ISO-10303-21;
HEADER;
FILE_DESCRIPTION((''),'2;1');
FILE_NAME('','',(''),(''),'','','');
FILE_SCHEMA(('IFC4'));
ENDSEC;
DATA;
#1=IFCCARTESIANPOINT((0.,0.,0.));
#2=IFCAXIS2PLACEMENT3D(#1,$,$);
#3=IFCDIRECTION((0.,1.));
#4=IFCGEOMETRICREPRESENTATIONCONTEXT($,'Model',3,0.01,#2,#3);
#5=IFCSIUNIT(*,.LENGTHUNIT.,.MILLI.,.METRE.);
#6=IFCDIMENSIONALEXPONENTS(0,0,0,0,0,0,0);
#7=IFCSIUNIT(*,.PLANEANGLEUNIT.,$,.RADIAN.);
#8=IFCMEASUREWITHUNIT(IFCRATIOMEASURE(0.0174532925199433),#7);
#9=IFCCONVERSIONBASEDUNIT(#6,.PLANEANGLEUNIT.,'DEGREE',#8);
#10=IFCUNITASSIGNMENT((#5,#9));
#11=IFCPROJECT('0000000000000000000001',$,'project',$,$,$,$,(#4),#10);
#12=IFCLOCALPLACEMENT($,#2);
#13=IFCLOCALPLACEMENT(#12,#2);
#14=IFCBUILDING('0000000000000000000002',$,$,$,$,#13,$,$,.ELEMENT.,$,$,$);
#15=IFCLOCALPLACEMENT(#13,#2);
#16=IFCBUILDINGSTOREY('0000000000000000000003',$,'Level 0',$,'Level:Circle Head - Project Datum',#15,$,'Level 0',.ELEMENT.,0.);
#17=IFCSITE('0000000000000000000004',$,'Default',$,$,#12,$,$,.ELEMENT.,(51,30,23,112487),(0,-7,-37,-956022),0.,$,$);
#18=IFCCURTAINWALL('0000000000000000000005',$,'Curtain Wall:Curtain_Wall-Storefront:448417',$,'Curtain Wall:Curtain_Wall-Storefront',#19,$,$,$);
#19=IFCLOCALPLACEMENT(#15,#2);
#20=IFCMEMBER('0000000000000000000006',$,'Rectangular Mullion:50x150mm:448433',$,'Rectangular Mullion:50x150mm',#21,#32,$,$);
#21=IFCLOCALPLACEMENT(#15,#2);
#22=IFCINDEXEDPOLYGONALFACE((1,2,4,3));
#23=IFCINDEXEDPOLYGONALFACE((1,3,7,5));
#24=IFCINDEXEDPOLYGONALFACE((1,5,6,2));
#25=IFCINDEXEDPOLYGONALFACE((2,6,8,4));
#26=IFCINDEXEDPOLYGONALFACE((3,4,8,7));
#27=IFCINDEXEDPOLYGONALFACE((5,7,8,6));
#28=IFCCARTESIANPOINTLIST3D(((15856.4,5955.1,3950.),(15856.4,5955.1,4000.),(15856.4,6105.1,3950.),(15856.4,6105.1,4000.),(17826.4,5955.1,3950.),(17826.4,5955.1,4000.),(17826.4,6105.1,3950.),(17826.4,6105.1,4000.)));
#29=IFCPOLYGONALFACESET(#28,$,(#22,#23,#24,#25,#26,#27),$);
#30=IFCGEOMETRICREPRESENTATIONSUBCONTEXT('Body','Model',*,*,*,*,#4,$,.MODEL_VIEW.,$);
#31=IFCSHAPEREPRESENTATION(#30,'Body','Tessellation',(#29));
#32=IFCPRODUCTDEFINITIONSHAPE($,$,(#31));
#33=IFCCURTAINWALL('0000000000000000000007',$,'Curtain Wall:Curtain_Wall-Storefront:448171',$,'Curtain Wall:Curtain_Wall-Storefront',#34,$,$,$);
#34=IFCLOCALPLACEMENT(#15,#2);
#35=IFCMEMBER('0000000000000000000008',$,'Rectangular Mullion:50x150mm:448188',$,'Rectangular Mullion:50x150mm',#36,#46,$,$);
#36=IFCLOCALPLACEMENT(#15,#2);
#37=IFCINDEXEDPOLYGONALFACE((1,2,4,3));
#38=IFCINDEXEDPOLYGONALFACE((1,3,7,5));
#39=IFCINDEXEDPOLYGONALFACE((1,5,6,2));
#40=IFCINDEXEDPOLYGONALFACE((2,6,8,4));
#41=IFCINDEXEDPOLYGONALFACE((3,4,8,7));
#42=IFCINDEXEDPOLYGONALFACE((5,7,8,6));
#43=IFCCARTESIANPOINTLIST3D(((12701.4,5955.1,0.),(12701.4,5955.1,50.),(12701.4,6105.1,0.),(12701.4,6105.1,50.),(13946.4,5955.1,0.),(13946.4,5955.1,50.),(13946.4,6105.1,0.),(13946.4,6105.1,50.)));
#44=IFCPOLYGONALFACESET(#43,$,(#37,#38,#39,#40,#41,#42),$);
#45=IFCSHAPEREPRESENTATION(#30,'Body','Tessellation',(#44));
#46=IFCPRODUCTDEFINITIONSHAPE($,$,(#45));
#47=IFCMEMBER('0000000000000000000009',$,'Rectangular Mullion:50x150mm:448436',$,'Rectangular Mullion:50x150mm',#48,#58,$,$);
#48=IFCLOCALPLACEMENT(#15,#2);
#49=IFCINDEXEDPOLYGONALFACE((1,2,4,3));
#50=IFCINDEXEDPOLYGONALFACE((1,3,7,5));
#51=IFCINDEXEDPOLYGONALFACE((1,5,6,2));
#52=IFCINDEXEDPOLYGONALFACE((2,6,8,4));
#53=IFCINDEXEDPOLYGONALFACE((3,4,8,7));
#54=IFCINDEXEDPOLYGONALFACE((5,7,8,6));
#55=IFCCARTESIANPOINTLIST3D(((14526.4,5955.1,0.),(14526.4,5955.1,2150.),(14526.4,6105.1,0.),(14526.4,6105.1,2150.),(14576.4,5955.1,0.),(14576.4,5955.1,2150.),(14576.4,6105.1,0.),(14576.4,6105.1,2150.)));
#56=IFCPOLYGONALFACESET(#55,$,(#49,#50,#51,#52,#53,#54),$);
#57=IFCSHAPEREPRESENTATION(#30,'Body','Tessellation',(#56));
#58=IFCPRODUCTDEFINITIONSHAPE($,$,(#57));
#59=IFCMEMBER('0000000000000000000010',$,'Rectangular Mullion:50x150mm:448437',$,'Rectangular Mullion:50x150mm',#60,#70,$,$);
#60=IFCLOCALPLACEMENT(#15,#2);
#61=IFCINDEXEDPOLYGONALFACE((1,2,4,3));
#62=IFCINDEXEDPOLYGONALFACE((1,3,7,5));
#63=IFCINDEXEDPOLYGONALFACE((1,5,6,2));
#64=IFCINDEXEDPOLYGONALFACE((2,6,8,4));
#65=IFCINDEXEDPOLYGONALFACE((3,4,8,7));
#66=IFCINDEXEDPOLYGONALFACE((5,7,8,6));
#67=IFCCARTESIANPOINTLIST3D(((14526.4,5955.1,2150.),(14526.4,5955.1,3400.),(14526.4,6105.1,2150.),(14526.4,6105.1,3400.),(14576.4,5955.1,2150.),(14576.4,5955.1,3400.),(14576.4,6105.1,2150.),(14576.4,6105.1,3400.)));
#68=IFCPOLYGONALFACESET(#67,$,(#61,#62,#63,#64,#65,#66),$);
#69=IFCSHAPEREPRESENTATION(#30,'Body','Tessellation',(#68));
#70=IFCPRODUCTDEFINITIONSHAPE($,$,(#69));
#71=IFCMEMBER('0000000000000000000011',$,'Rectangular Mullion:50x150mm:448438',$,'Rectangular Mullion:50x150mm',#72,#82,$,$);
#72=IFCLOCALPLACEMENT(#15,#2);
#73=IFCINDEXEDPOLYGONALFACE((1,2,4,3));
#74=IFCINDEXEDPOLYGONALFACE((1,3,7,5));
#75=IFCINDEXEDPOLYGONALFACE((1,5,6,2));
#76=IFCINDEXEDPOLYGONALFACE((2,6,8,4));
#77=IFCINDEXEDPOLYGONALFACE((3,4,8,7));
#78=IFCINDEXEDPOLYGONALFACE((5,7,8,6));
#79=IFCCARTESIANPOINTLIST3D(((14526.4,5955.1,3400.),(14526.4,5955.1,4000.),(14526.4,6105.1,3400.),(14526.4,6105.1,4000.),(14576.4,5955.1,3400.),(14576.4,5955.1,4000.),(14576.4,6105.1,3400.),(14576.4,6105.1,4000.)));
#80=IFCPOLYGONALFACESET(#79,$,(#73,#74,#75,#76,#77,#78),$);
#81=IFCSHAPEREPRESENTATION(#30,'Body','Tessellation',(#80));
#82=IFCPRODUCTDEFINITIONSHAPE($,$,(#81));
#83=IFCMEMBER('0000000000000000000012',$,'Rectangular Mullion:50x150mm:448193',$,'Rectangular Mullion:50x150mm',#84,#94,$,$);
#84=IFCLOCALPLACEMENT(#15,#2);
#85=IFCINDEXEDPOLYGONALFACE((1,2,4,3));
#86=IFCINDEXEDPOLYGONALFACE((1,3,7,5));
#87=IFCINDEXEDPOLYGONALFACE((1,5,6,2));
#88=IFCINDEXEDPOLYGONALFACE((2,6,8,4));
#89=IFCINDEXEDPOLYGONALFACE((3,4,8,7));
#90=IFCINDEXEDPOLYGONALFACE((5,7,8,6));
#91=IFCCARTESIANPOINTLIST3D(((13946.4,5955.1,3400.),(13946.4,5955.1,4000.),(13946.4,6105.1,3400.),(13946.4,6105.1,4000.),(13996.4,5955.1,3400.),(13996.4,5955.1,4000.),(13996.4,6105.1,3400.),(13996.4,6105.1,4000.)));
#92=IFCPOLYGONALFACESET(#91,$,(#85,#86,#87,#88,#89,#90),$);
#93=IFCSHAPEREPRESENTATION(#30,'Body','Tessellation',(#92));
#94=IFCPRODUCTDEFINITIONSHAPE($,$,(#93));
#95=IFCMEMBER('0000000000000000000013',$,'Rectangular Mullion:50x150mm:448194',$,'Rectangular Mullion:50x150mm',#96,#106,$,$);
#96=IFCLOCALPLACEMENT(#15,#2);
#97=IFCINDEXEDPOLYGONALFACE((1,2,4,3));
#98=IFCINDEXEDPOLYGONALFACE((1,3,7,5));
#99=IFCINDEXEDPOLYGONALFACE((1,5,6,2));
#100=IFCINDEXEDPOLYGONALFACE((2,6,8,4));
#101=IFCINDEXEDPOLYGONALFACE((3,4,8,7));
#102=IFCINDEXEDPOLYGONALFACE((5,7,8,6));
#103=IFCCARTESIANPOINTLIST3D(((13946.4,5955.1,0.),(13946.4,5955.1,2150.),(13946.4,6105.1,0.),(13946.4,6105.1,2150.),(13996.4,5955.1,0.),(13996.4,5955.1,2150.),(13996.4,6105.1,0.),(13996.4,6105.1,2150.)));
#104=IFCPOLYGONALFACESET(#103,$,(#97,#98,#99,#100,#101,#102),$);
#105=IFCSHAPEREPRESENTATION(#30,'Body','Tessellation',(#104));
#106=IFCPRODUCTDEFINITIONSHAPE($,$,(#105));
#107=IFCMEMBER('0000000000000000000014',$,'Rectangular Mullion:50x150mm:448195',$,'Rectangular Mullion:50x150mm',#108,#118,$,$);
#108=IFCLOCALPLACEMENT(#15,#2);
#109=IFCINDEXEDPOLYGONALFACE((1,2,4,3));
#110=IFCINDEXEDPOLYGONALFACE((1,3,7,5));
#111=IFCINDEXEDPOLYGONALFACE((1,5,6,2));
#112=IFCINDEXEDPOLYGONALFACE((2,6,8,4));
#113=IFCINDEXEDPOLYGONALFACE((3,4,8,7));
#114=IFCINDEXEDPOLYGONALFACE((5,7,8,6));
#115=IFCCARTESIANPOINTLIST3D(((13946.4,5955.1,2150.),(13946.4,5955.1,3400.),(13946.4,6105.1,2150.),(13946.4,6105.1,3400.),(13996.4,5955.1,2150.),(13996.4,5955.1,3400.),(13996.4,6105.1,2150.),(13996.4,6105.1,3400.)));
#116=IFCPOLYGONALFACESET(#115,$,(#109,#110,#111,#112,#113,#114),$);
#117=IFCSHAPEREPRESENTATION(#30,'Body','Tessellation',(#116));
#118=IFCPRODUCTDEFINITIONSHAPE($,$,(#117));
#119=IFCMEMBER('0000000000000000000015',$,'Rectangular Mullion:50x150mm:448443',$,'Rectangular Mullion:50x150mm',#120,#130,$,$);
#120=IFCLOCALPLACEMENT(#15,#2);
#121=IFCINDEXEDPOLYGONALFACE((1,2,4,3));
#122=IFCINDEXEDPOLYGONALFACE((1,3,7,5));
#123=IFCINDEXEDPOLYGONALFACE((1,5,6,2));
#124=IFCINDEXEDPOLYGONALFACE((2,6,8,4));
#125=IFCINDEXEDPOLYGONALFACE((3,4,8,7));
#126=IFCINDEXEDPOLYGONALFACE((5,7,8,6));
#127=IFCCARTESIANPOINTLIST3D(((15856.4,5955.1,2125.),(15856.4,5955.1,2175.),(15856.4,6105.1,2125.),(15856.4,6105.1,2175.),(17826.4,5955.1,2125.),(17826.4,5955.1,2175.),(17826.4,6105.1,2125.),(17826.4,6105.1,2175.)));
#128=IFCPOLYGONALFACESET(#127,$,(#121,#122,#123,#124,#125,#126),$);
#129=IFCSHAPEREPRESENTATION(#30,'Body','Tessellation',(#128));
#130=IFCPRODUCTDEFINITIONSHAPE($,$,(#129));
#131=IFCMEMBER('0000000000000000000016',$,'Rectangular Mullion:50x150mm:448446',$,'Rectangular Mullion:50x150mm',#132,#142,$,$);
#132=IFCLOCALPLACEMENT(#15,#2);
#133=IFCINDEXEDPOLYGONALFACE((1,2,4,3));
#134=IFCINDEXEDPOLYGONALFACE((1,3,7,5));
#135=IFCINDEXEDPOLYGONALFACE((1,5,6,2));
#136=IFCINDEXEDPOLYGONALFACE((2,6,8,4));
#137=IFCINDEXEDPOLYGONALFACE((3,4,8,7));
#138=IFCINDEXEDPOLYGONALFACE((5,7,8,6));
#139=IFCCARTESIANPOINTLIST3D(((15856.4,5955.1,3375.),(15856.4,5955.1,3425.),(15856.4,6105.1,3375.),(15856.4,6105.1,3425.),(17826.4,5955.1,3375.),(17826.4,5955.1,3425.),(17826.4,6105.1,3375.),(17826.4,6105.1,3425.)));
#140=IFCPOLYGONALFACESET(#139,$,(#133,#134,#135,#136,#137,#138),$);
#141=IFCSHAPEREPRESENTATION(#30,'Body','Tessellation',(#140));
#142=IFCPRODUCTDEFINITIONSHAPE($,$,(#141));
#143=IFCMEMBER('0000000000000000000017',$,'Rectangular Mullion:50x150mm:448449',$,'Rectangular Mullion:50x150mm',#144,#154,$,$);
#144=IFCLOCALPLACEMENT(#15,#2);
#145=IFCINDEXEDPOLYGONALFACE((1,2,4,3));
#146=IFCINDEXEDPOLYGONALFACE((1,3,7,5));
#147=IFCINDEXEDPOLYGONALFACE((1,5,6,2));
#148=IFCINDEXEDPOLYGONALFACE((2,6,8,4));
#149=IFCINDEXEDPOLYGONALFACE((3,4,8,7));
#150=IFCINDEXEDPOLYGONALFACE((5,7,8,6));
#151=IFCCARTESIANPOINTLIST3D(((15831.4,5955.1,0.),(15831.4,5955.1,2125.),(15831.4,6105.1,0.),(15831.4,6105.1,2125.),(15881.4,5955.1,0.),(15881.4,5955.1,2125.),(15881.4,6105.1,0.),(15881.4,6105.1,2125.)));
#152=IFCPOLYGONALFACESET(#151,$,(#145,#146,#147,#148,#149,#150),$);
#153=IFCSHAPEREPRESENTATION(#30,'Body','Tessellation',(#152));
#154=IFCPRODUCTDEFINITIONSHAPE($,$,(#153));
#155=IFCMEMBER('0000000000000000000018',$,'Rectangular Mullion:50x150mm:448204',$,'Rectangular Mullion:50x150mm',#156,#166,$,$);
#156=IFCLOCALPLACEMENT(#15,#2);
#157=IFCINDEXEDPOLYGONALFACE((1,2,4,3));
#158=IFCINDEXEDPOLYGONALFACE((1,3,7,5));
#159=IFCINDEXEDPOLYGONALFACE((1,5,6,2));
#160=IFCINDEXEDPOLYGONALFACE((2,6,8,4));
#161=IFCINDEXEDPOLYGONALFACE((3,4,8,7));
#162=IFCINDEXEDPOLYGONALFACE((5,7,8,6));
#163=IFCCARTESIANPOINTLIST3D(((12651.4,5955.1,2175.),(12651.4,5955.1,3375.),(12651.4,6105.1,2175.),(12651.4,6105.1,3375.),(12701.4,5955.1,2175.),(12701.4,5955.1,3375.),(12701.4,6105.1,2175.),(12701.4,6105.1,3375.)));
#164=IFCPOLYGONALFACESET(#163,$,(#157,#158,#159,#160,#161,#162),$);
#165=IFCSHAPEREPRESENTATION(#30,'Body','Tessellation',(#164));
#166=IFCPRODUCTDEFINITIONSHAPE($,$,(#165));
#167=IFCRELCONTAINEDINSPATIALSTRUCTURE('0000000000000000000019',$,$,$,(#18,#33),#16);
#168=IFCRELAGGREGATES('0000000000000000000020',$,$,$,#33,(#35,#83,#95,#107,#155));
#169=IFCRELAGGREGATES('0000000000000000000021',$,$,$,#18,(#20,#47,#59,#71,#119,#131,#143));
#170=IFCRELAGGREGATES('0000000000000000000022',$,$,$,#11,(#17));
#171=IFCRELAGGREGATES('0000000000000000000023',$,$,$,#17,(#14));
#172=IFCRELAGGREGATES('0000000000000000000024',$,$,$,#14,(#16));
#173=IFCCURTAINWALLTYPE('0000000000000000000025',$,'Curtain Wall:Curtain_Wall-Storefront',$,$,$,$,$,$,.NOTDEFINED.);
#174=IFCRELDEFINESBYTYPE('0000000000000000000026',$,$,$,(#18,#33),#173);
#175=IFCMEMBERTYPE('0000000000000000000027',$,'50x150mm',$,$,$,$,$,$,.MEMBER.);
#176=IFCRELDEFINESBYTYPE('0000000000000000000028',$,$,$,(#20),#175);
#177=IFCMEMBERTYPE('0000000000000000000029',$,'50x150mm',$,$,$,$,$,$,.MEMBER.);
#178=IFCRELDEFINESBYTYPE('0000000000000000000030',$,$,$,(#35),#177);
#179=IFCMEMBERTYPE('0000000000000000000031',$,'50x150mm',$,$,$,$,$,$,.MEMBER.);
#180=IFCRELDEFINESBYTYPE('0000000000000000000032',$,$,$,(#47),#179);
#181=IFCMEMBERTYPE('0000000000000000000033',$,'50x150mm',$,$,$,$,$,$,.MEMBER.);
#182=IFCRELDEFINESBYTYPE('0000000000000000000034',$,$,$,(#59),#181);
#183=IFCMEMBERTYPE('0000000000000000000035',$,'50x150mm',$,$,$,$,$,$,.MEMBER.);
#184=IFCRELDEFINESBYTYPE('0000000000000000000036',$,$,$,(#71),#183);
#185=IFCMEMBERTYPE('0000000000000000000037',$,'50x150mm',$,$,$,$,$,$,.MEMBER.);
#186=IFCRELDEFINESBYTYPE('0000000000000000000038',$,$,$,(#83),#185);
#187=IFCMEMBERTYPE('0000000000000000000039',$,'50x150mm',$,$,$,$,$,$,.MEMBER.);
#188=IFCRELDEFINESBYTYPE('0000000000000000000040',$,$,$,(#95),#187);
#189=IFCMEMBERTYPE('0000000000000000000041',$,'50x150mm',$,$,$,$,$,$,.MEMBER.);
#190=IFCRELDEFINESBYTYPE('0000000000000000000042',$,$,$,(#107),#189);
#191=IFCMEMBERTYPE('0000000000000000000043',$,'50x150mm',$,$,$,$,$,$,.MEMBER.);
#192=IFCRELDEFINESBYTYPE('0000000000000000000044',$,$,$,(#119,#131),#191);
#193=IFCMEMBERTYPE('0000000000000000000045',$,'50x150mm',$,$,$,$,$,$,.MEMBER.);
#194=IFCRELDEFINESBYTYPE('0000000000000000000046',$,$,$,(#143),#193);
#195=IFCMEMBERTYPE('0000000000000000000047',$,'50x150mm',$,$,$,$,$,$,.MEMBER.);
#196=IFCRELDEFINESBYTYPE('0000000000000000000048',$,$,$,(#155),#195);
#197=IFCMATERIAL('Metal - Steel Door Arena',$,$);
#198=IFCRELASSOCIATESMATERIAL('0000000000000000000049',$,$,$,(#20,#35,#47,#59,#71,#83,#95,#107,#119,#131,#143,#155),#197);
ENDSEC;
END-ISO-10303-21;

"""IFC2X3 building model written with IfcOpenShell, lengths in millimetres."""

from ifc_helpers import new_model, entity, si_unit, converted_unit, direction, frame, origin, origin_2d_with_axis, place, context, subcontext, project, spatial, rectangle, extrude, source, transform, mapped, material, type_object, type_shapes, element, aggregate, save


model = new_model("IFC2X3")

# Units and contexts
model_context = context("Model", 3, precision=0.01, world=origin(), true_north=direction((0.0, 1.0)))
body_context = subcontext(model_context, "Body", "Model", "MODEL_VIEW")
ifc_project = project(units=[si_unit("LENGTHUNIT", "METRE", prefix="MILLI"), converted_unit("PLANEANGLEUNIT", "DEGREE", entity("IfcRatioMeasure", 0.0174532925199433), si_unit("PLANEANGLEUNIT", "RADIAN"), dimensions=[0, 0, 0, 0, 0, 0, 0])], contexts=[model_context])

# Site, building, storey
site_placement = place(None, origin())
site = spatial("IfcSite", under=ifc_project, at=site_placement, Name="Default", CompositionType="ELEMENT", RefLatitude=(51, 30, 23, 112487), RefLongitude=(0, -7, -37, -956022), RefElevation=0.0)
building_placement = place(site_placement, origin())
building = spatial("IfcBuilding", under=site, at=building_placement, CompositionType="ELEMENT")
storey_placement = place(building_placement, origin())
storey = spatial("IfcBuildingStorey", under=building, at=storey_placement, Name="Level 0", ObjectType="Level:Circle Head - Project Datum", LongName="Level 0", CompositionType="ELEMENT", Elevation=0.0)

# Curtain walls, members
curtain_wall_type = type_object("IfcCurtainWallType", Name="Curtain Wall:Curtain_Wall-Storefront", PredefinedType="NOTDEFINED")
curtain_wall_1_placement = place(storey_placement, origin())
curtain_wall_1 = element("IfcCurtainWall", 1, at=curtain_wall_1_placement, inside=storey, type_object=curtain_wall_type, Name="Curtain Wall:Curtain_Wall-Storefront:448417", ObjectType="Curtain Wall:Curtain_Wall-Storefront")
ifc_material_1 = material(Name="Metal - Steel Door Arena")
member_type_1 = type_object("IfcMemberType", Name="50x150mm", PredefinedType="MEMBER")
shared_shape_1 = source(origin(), body_context, "Body", "SweptSolid", [
    extrude(rectangle(XDim=150.0, YDim=50.0, at=origin_2d_with_axis()), frame((-25.0, 0.0, -1970.0), z_axis=(0.0, 0.0, 1.0), x_axis=(0.0, -1.0, 0.0)), (0.0, 0.0, 1.0), 1970.0),
])
type_shapes(member_type_1, [shared_shape_1])
member_1_placement = place(storey_placement, frame((15856.4, 6030.1, 4000.0), z_axis=(-1.0, 0.0, 0.0), x_axis=(0.0, 0.0, 1.0)))
member_1 = element("IfcMember", 2, at=member_1_placement, type_object=member_type_1, material=ifc_material_1, Name="Rectangular Mullion:50x150mm:448433", ObjectType="Rectangular Mullion:50x150mm", context=body_context, shape_type="MappedRepresentation", body=[
    mapped(shared_shape_1, transform((0.0, 0.0, 0.0), scale=1.0)),
])
curtain_wall_2_placement = place(storey_placement, origin())
curtain_wall_2 = element("IfcCurtainWall", 3, at=curtain_wall_2_placement, inside=storey, type_object=curtain_wall_type, Name="Curtain Wall:Curtain_Wall-Storefront:448171", ObjectType="Curtain Wall:Curtain_Wall-Storefront")
member_type_2 = type_object("IfcMemberType", Name="50x150mm", PredefinedType="MEMBER")
shared_shape_2 = source(origin(), body_context, "Body", "SweptSolid", [
    extrude(rectangle(XDim=150.0, YDim=50.0, at=origin_2d_with_axis()), frame((-25.0, 0.0, -1245.0), z_axis=(0.0, 0.0, 1.0), x_axis=(0.0, -1.0, 0.0)), (0.0, 0.0, 1.0), 1245.0),
])
type_shapes(member_type_2, [shared_shape_2])
member_2_placement = place(storey_placement, frame((13946.4, 6030.1, 0.0), z_axis=(1.0, 0.0, 0.0), x_axis=(0.0, 0.0, -1.0)))
member_2 = element("IfcMember", 4, at=member_2_placement, type_object=member_type_2, material=ifc_material_1, Name="Rectangular Mullion:50x150mm:448188", ObjectType="Rectangular Mullion:50x150mm", context=body_context, shape_type="MappedRepresentation", body=[
    mapped(shared_shape_2, transform((0.0, 0.0, 0.0), scale=1.0)),
])

# Members
member_type_3 = type_object("IfcMemberType", Name="50x150mm", PredefinedType="MEMBER")
shared_shape_3 = source(origin(), body_context, "Body", "SweptSolid", [
    extrude(rectangle(XDim=150.0, YDim=50.0, at=origin_2d_with_axis()), frame((-25.0, 0.0, -2150.0), z_axis=(0.0, 0.0, 1.0), x_axis=(0.0, -1.0, 0.0)), (0.0, 0.0, 1.0), 2150.0),
])
type_shapes(member_type_3, [shared_shape_3])
member_3_placement = place(storey_placement, frame((14526.4, 6030.1, 0.0), z_axis=(0.0, 0.0, -1.0), x_axis=(-1.0, 0.0, 0.0)))
member_3 = element("IfcMember", 5, at=member_3_placement, type_object=member_type_3, material=ifc_material_1, Name="Rectangular Mullion:50x150mm:448436", ObjectType="Rectangular Mullion:50x150mm", context=body_context, shape_type="MappedRepresentation", body=[
    mapped(shared_shape_3, transform((0.0, 0.0, 0.0), scale=1.0)),
])
member_type_4 = type_object("IfcMemberType", Name="50x150mm", PredefinedType="MEMBER")
shared_shape_4 = source(origin(), body_context, "Body", "SweptSolid", [
    extrude(rectangle(XDim=150.0, YDim=50.0, at=origin_2d_with_axis()), frame((-25.0, 0.0, -1250.0), z_axis=(0.0, 0.0, 1.0), x_axis=(0.0, -1.0, 0.0)), (0.0, 0.0, 1.0), 1250.0),
])
type_shapes(member_type_4, [shared_shape_4])
member_4_placement = place(storey_placement, frame((14526.4, 6030.1, 2150.0), z_axis=(0.0, 0.0, -1.0), x_axis=(-1.0, 0.0, 0.0)))
member_4 = element("IfcMember", 6, at=member_4_placement, type_object=member_type_4, material=ifc_material_1, Name="Rectangular Mullion:50x150mm:448437", ObjectType="Rectangular Mullion:50x150mm", context=body_context, shape_type="MappedRepresentation", body=[
    mapped(shared_shape_4, transform((0.0, 0.0, 0.0), scale=1.0)),
])
member_type_5 = type_object("IfcMemberType", Name="50x150mm", PredefinedType="MEMBER")
shared_shape_5 = source(origin(), body_context, "Body", "SweptSolid", [
    extrude(rectangle(XDim=150.0, YDim=50.0, at=origin_2d_with_axis()), frame((-25.0, 0.0, -600.0), z_axis=(0.0, 0.0, 1.0), x_axis=(0.0, -1.0, 0.0)), (0.0, 0.0, 1.0), 600.0),
])
type_shapes(member_type_5, [shared_shape_5])
member_5_placement = place(storey_placement, frame((14526.4, 6030.1, 3400.0), z_axis=(0.0, 0.0, -1.0), x_axis=(-1.0, 0.0, 0.0)))
member_5 = element("IfcMember", 7, at=member_5_placement, type_object=member_type_5, material=ifc_material_1, Name="Rectangular Mullion:50x150mm:448438", ObjectType="Rectangular Mullion:50x150mm", context=body_context, shape_type="MappedRepresentation", body=[
    mapped(shared_shape_5, transform((0.0, 0.0, 0.0), scale=1.0)),
])
member_type_6 = type_object("IfcMemberType", Name="50x150mm", PredefinedType="MEMBER")
shared_shape_6 = source(origin(), body_context, "Body", "SweptSolid", [
    extrude(rectangle(XDim=150.0, YDim=50.0, at=origin_2d_with_axis()), frame((-25.0, 0.0, -600.0), z_axis=(0.0, 0.0, 1.0), x_axis=(0.0, -1.0, 0.0)), (0.0, 0.0, 1.0), 600.0),
])
type_shapes(member_type_6, [shared_shape_6])
member_6_placement = place(storey_placement, frame((13996.4, 6030.1, 4000.0)))
member_6 = element("IfcMember", 8, at=member_6_placement, type_object=member_type_6, material=ifc_material_1, Name="Rectangular Mullion:50x150mm:448193", ObjectType="Rectangular Mullion:50x150mm", context=body_context, shape_type="MappedRepresentation", body=[
    mapped(shared_shape_6, transform((0.0, 0.0, 0.0), scale=1.0)),
])
member_type_7 = type_object("IfcMemberType", Name="50x150mm", PredefinedType="MEMBER")
shared_shape_7 = source(origin(), body_context, "Body", "SweptSolid", [
    extrude(rectangle(XDim=150.0, YDim=50.0, at=origin_2d_with_axis()), frame((-25.0, 0.0, -2150.0), z_axis=(0.0, 0.0, 1.0), x_axis=(0.0, -1.0, 0.0)), (0.0, 0.0, 1.0), 2150.0),
])
type_shapes(member_type_7, [shared_shape_7])
member_7_placement = place(storey_placement, frame((13996.4, 6030.1, 2150.0)))
member_7 = element("IfcMember", 9, at=member_7_placement, type_object=member_type_7, material=ifc_material_1, Name="Rectangular Mullion:50x150mm:448194", ObjectType="Rectangular Mullion:50x150mm", context=body_context, shape_type="MappedRepresentation", body=[
    mapped(shared_shape_7, transform((0.0, 0.0, 0.0), scale=1.0)),
])
member_type_8 = type_object("IfcMemberType", Name="50x150mm", PredefinedType="MEMBER")
shared_shape_8 = source(origin(), body_context, "Body", "SweptSolid", [
    extrude(rectangle(XDim=150.0, YDim=50.0, at=origin_2d_with_axis()), frame((-25.0, 0.0, -1250.0), z_axis=(0.0, 0.0, 1.0), x_axis=(0.0, -1.0, 0.0)), (0.0, 0.0, 1.0), 1250.0),
])
type_shapes(member_type_8, [shared_shape_8])
member_8_placement = place(storey_placement, frame((13996.4, 6030.1, 3400.0)))
member_8 = element("IfcMember", 10, at=member_8_placement, type_object=member_type_8, material=ifc_material_1, Name="Rectangular Mullion:50x150mm:448195", ObjectType="Rectangular Mullion:50x150mm", context=body_context, shape_type="MappedRepresentation", body=[
    mapped(shared_shape_8, transform((0.0, 0.0, 0.0), scale=1.0)),
])
member_type_9 = type_object("IfcMemberType", Name="50x150mm", PredefinedType="MEMBER")
shared_shape_9 = source(origin(), body_context, "Body", "SweptSolid", [
    extrude(rectangle(XDim=150.0, YDim=50.0, at=origin_2d_with_axis()), frame((0.0, 0.0, -1970.0), z_axis=(0.0, 0.0, 1.0), x_axis=(0.0, -1.0, 0.0)), (0.0, 0.0, 1.0), 1970.0),
])
type_shapes(member_type_9, [shared_shape_9])
member_9_placement = place(storey_placement, frame((15856.4, 6030.1, 2150.0), z_axis=(-1.0, 0.0, 0.0), x_axis=(0.0, 0.0, 1.0)))
member_9 = element("IfcMember", 11, at=member_9_placement, type_object=member_type_9, material=ifc_material_1, Name="Rectangular Mullion:50x150mm:448443", ObjectType="Rectangular Mullion:50x150mm", context=body_context, shape_type="MappedRepresentation", body=[
    mapped(shared_shape_9, transform((0.0, 0.0, 0.0), scale=1.0)),
])
member_10_placement = place(storey_placement, frame((15856.4, 6030.1, 3400.0), z_axis=(-1.0, 0.0, 0.0), x_axis=(0.0, 0.0, 1.0)))
member_10 = element("IfcMember", 12, at=member_10_placement, type_object=member_type_9, material=ifc_material_1, Name="Rectangular Mullion:50x150mm:448446", ObjectType="Rectangular Mullion:50x150mm", context=body_context, shape_type="MappedRepresentation", body=[
    mapped(shared_shape_9, transform((0.0, 0.0, 0.0), scale=1.0)),
])
member_type_10 = type_object("IfcMemberType", Name="50x150mm", PredefinedType="MEMBER")
shared_shape_10 = source(origin(), body_context, "Body", "SweptSolid", [
    extrude(rectangle(XDim=150.0, YDim=50.0, at=origin_2d_with_axis()), frame((0.0, 0.0, -2125.0), z_axis=(0.0, 0.0, 1.0), x_axis=(0.0, -1.0, 0.0)), (0.0, 0.0, 1.0), 2125.0),
])
type_shapes(member_type_10, [shared_shape_10])
member_11_placement = place(storey_placement, frame((15856.4, 6030.1, 0.0), z_axis=(0.0, 0.0, -1.0), x_axis=(-1.0, 0.0, 0.0)))
member_11 = element("IfcMember", 13, at=member_11_placement, type_object=member_type_10, material=ifc_material_1, Name="Rectangular Mullion:50x150mm:448449", ObjectType="Rectangular Mullion:50x150mm", context=body_context, shape_type="MappedRepresentation", body=[
    mapped(shared_shape_10, transform((0.0, 0.0, 0.0), scale=1.0)),
])
member_type_11 = type_object("IfcMemberType", Name="50x150mm", PredefinedType="MEMBER")
shared_shape_11 = source(origin(), body_context, "Body", "SweptSolid", [
    extrude(rectangle(XDim=150.0, YDim=50.0, at=origin_2d_with_axis()), frame((0.0, 0.0, -1200.0), z_axis=(0.0, 0.0, 1.0), x_axis=(0.0, -1.0, 0.0)), (0.0, 0.0, 1.0), 1200.0),
])
type_shapes(member_type_11, [shared_shape_11])
member_12_placement = place(storey_placement, frame((12676.4, 6030.1, 2175.0), z_axis=(0.0, 0.0, -1.0), x_axis=(-1.0, 0.0, 0.0)))
member_12 = element("IfcMember", 14, at=member_12_placement, type_object=member_type_11, material=ifc_material_1, Name="Rectangular Mullion:50x150mm:448204", ObjectType="Rectangular Mullion:50x150mm", context=body_context, shape_type="MappedRepresentation", body=[
    mapped(shared_shape_11, transform((0.0, 0.0, 0.0), scale=1.0)),
])

aggregate(curtain_wall_2, [member_2, member_6, member_7, member_8, member_12])
aggregate(curtain_wall_1, [member_1, member_3, member_4, member_5, member_9, member_10, member_11])

save(model, "model.ifc")
